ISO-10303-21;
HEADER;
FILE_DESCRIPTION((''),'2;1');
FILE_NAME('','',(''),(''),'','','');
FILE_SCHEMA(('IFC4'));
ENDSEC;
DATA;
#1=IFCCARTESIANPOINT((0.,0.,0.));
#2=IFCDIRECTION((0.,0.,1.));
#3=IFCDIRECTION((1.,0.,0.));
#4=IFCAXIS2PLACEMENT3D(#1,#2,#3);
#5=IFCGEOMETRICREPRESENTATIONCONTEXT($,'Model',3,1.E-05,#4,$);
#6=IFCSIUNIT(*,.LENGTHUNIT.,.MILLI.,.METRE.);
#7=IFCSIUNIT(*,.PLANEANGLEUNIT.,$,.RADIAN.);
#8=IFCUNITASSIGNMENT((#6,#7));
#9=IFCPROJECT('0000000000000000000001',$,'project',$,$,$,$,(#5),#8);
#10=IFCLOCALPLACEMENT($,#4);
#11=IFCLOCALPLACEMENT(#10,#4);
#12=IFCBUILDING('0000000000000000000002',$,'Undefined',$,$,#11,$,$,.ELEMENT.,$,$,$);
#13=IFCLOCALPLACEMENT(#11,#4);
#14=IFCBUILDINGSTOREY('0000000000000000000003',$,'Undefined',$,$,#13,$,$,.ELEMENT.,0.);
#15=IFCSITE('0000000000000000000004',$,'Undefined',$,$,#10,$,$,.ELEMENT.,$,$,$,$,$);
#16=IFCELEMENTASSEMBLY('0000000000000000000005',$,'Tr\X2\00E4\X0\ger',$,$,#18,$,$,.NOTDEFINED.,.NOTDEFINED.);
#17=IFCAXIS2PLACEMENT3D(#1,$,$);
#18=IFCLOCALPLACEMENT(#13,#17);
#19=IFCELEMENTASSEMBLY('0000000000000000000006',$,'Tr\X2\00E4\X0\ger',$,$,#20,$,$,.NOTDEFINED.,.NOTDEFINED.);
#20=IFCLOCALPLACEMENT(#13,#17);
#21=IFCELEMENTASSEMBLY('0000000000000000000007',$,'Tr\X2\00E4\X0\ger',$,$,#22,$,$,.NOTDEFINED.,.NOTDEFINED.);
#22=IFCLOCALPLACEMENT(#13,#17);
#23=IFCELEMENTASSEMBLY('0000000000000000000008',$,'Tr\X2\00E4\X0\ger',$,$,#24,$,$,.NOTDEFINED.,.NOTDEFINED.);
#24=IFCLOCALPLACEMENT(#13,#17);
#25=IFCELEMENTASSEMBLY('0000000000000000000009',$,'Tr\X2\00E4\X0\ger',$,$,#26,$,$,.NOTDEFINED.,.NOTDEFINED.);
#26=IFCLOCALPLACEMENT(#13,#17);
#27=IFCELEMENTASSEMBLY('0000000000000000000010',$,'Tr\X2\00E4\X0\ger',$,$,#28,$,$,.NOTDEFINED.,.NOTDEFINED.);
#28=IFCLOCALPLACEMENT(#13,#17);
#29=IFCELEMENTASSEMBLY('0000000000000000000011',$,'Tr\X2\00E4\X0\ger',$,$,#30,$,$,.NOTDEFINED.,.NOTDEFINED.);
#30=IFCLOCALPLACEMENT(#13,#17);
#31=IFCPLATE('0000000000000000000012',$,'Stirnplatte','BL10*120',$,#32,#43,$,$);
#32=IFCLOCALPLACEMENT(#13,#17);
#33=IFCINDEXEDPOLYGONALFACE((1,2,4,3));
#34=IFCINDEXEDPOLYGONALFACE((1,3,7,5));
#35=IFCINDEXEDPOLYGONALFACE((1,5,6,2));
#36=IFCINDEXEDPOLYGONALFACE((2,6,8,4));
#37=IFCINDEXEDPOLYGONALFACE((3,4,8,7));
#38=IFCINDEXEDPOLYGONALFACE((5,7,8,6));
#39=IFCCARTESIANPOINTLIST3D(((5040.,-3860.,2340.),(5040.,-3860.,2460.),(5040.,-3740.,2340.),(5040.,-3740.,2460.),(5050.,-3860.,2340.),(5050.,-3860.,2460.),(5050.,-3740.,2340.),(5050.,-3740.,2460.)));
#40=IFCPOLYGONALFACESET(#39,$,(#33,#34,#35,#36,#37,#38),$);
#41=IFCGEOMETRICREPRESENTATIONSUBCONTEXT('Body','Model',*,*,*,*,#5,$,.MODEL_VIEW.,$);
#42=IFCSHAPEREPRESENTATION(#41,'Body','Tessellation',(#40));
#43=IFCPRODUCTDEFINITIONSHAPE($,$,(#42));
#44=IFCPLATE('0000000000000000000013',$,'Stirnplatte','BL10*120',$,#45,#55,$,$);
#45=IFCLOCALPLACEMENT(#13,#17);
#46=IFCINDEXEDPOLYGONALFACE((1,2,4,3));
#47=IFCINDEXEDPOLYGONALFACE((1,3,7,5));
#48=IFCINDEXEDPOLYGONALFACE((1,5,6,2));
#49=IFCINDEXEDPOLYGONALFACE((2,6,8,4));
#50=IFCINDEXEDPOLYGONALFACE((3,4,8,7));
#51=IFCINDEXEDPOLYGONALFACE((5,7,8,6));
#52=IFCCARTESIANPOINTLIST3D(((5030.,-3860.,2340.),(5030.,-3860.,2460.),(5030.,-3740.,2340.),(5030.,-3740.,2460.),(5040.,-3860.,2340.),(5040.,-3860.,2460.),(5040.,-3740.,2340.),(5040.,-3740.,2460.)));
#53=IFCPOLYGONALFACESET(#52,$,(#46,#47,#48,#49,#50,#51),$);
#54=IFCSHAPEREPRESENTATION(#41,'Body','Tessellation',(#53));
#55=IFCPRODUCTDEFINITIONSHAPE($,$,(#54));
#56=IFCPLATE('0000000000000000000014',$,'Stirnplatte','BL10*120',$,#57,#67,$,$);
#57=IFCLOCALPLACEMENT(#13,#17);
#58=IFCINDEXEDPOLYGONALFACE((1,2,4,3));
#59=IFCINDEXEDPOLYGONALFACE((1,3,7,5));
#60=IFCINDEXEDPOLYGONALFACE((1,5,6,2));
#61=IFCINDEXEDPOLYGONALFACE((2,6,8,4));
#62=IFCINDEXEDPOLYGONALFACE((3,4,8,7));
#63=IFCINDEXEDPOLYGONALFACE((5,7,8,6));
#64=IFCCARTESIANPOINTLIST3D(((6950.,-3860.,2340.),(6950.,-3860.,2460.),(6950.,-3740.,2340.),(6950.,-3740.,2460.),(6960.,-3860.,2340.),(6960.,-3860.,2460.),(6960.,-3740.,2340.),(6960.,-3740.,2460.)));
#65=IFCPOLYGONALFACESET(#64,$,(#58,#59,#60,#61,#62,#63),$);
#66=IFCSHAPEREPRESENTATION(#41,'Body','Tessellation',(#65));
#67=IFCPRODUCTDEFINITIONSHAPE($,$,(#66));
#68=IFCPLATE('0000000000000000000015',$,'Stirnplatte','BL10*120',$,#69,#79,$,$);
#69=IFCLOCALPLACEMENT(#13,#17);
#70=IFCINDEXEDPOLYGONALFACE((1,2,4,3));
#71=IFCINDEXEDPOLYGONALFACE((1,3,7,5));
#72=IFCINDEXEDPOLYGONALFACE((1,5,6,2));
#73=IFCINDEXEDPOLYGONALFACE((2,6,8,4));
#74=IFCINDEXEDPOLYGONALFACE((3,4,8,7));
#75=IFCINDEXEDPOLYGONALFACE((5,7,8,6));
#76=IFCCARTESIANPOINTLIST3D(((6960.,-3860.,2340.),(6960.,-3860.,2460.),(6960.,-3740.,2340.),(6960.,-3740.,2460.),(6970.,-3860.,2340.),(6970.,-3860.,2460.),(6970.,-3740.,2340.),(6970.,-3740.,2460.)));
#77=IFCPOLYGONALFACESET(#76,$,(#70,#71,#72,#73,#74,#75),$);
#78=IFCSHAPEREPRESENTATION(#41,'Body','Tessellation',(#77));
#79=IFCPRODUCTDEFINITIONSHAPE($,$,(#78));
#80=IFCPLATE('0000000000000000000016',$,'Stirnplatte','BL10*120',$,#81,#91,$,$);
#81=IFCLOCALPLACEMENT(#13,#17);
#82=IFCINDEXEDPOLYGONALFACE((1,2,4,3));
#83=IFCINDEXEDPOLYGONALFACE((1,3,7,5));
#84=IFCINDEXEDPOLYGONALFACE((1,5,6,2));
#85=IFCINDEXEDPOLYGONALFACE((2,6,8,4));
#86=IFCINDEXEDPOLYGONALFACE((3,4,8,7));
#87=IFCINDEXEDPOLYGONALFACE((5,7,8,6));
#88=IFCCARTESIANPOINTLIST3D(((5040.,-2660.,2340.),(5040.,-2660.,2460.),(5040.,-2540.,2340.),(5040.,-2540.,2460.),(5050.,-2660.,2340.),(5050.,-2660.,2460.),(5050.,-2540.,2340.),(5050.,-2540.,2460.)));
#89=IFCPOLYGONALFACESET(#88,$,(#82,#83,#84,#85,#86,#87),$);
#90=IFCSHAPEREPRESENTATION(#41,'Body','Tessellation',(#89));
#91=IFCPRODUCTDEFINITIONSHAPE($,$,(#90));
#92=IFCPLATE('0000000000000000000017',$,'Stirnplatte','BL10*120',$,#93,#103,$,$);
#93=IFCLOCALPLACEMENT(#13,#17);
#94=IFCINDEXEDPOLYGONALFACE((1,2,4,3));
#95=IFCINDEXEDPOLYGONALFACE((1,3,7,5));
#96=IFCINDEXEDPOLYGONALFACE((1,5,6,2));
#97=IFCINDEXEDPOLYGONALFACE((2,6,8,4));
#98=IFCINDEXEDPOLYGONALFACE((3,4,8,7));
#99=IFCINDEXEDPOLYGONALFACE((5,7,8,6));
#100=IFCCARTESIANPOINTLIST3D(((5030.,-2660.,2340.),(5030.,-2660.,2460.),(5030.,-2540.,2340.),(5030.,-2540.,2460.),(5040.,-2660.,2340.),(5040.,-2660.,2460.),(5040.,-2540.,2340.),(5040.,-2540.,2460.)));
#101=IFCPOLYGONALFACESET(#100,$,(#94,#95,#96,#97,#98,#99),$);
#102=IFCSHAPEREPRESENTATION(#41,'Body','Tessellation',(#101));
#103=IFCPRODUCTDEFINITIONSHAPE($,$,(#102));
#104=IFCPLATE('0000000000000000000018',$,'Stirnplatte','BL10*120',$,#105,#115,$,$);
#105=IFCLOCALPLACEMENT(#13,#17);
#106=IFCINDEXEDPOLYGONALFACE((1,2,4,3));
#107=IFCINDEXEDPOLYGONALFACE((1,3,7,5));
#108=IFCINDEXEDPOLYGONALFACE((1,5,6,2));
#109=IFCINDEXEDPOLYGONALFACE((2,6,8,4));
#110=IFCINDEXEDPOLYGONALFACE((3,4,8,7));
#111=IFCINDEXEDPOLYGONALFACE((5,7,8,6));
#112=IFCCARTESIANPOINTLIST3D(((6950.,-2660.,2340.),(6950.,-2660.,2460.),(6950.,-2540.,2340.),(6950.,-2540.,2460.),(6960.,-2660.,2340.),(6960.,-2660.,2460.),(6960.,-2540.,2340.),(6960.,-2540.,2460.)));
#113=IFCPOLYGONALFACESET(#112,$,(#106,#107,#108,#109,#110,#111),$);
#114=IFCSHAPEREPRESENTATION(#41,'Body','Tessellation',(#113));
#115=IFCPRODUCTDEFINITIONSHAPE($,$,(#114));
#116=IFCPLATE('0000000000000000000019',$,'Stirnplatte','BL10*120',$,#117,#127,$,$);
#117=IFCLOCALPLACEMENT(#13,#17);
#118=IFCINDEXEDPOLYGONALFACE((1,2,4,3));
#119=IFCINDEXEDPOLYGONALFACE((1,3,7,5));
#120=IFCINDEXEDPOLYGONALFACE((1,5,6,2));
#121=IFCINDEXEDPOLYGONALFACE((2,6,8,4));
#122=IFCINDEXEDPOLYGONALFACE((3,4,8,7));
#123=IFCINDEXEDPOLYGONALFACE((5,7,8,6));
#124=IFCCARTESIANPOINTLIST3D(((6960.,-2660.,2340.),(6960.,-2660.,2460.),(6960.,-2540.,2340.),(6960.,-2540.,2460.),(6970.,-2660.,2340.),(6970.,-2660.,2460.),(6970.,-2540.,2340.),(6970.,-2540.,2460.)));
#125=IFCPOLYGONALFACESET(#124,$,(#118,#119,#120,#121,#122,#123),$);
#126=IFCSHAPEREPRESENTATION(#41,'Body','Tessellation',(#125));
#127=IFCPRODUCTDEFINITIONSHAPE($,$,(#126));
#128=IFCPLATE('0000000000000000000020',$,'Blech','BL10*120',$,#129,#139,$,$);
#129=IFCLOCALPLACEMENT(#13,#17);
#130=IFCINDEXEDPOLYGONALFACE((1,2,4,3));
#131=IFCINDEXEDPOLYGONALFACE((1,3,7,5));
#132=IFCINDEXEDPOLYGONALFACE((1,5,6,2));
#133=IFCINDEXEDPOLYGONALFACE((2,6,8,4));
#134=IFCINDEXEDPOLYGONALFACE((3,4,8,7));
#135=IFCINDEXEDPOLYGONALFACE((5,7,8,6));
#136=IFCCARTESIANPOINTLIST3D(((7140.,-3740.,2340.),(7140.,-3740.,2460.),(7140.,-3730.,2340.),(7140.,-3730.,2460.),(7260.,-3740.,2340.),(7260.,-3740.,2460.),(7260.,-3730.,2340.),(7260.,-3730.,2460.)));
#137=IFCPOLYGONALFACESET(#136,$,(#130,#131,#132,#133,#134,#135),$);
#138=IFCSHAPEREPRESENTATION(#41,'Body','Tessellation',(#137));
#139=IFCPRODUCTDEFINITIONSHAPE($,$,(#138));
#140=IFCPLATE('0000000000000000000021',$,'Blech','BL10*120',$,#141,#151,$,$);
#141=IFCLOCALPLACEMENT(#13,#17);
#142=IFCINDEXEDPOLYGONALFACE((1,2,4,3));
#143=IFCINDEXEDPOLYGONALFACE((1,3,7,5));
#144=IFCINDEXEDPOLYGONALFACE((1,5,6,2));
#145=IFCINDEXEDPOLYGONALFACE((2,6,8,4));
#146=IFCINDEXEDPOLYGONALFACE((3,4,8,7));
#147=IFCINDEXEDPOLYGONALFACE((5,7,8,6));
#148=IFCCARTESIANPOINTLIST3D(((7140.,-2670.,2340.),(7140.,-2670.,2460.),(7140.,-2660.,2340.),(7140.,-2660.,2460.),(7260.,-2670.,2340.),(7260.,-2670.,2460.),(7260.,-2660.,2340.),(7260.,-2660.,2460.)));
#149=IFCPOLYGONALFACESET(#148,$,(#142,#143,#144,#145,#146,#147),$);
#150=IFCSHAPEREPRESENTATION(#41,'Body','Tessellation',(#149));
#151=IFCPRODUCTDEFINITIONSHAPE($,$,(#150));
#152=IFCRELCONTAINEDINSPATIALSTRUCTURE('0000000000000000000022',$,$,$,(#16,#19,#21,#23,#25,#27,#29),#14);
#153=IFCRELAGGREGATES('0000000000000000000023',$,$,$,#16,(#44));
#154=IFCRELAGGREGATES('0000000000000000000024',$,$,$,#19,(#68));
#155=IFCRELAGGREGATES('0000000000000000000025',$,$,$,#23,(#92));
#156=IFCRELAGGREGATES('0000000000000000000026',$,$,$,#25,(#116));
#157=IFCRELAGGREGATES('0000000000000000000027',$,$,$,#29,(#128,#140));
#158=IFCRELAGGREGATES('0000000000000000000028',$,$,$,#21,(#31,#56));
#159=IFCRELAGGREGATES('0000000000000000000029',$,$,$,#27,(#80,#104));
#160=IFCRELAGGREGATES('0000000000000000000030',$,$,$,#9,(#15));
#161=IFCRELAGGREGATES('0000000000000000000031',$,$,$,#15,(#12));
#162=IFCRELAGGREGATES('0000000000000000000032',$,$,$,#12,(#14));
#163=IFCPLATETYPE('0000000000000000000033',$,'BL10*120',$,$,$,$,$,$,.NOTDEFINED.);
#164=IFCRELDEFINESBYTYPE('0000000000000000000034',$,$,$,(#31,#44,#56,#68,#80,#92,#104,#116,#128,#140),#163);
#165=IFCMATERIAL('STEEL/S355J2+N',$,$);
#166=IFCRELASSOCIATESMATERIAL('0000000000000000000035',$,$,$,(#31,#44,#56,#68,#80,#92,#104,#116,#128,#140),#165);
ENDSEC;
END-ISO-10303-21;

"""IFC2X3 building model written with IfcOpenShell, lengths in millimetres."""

from ifc_helpers import new_model, si_unit, frame, origin_with_axes, place, context, subcontext, project, spatial, polyline, outline, extrude, material, type_object, element, aggregate, save


model = new_model("IFC2X3")

# Units and contexts
model_context = context("Model", 3, precision=1e-05, world=origin_with_axes())
body_context = subcontext(model_context, "Body", "Model", "MODEL_VIEW")
ifc_project = project(units=[si_unit("LENGTHUNIT", "METRE", prefix="MILLI"), si_unit("PLANEANGLEUNIT", "RADIAN")], contexts=[model_context])

# Site, building, storey
site_placement = place(None, origin_with_axes())
site = spatial("IfcSite", under=ifc_project, at=site_placement, Name="Undefined", CompositionType="ELEMENT")
building_placement = place(site_placement, origin_with_axes())
building = spatial("IfcBuilding", under=site, at=building_placement, Name="Undefined", CompositionType="ELEMENT")
storey_placement = place(building_placement, origin_with_axes())
storey = spatial("IfcBuildingStorey", under=building, at=storey_placement, Name="Undefined", CompositionType="ELEMENT", Elevation=0.0)

# Element assemblies
assembly_1_placement = place(storey_placement, origin_with_axes())
assembly_1 = element("IfcElementAssembly", 1, at=assembly_1_placement, inside=storey, Name="Träger", AssemblyPlace="NOTDEFINED", PredefinedType="NOTDEFINED")
assembly_2_placement = place(storey_placement, origin_with_axes())
assembly_2 = element("IfcElementAssembly", 2, at=assembly_2_placement, inside=storey, Name="Träger", AssemblyPlace="NOTDEFINED", PredefinedType="NOTDEFINED")
assembly_3_placement = place(storey_placement, origin_with_axes())
assembly_3 = element("IfcElementAssembly", 3, at=assembly_3_placement, inside=storey, Name="Träger", AssemblyPlace="NOTDEFINED", PredefinedType="NOTDEFINED")
assembly_4_placement = place(storey_placement, origin_with_axes())
assembly_4 = element("IfcElementAssembly", 4, at=assembly_4_placement, inside=storey, Name="Träger", AssemblyPlace="NOTDEFINED", PredefinedType="NOTDEFINED")
assembly_5_placement = place(storey_placement, origin_with_axes())
assembly_5 = element("IfcElementAssembly", 5, at=assembly_5_placement, inside=storey, Name="Träger", AssemblyPlace="NOTDEFINED", PredefinedType="NOTDEFINED")
assembly_6_placement = place(storey_placement, origin_with_axes())
assembly_6 = element("IfcElementAssembly", 6, at=assembly_6_placement, inside=storey, Name="Träger", AssemblyPlace="NOTDEFINED", PredefinedType="NOTDEFINED")
assembly_7_placement = place(storey_placement, origin_with_axes())
assembly_7 = element("IfcElementAssembly", 7, at=assembly_7_placement, inside=storey, Name="Träger", AssemblyPlace="NOTDEFINED", PredefinedType="NOTDEFINED")

# Plates
ifc_material_1 = material(Name="STEEL/S355J2+N")
plate_type = type_object("IfcPlateType", Name="BL10*120", PredefinedType="NOTDEFINED")
plate_1_placement = place(assembly_3_placement, frame((5045.0, -3800.0, 2340.0), z_axis=(1.0, 0.0, 0.0), x_axis=(0.0, 0.0, 1.0)))
plate_1 = element("IfcPlate", 8, at=plate_1_placement, type_object=plate_type, material=ifc_material_1, Name="Stirnplatte", Description="BL10*120", context=body_context, shape_type="SweptSolid", body=[
    extrude(outline(polyline([(0.0, -60.0), (0.0, 60.0), (120.0, 60.0), (120.0, -60.0), (0.0, -60.0)])), frame((0.0, 0.0, -5.0), z_axis=(0.0, 0.0, 1.0), x_axis=(1.0, 0.0, 0.0)), (0.0, 0.0, 1.0), 10.0),
])
plate_2_placement = place(assembly_1_placement, frame((5035.0, -3800.0, 2340.0), z_axis=(1.0, 0.0, 0.0), x_axis=(0.0, 0.0, 1.0)))
plate_2 = element("IfcPlate", 9, at=plate_2_placement, type_object=plate_type, material=ifc_material_1, Name="Stirnplatte", Description="BL10*120", context=body_context, shape_type="SweptSolid", body=[
    extrude(outline(polyline([(0.0, -60.0), (0.0, 60.0), (120.0, 60.0), (120.0, -60.0), (0.0, -60.0)])), frame((0.0, 0.0, -5.0), z_axis=(0.0, 0.0, 1.0), x_axis=(1.0, 0.0, 0.0)), (0.0, 0.0, 1.0), 10.0),
])
aggregate(assembly_1, [plate_2])
plate_3_placement = place(assembly_3_placement, frame((6955.0, -3800.0, 2340.0), z_axis=(-1.0, 0.0, 0.0), x_axis=(0.0, 0.0, 1.0)))
plate_3 = element("IfcPlate", 10, at=plate_3_placement, type_object=plate_type, material=ifc_material_1, Name="Stirnplatte", Description="BL10*120", context=body_context, shape_type="SweptSolid", body=[
    extrude(outline(polyline([(0.0, -60.0), (0.0, 60.0), (120.0, 60.0), (120.0, -60.0), (0.0, -60.0)])), frame((0.0, 0.0, -5.0), z_axis=(0.0, 0.0, 1.0), x_axis=(1.0, 0.0, 0.0)), (0.0, 0.0, 1.0), 10.0),
])
plate_4_placement = place(assembly_2_placement, frame((6965.0, -3800.0, 2340.0), z_axis=(-1.0, 0.0, 0.0), x_axis=(0.0, 0.0, 1.0)))
plate_4 = element("IfcPlate", 11, at=plate_4_placement, type_object=plate_type, material=ifc_material_1, Name="Stirnplatte", Description="BL10*120", context=body_context, shape_type="SweptSolid", body=[
    extrude(outline(polyline([(0.0, -60.0), (0.0, 60.0), (120.0, 60.0), (120.0, -60.0), (0.0, -60.0)])), frame((0.0, 0.0, -5.0), z_axis=(0.0, 0.0, 1.0), x_axis=(1.0, 0.0, 0.0)), (0.0, 0.0, 1.0), 10.0),
])
aggregate(assembly_2, [plate_4])
plate_5_placement = place(assembly_6_placement, frame((5045.0, -2600.0, 2340.0), z_axis=(1.0, 0.0, 0.0), x_axis=(0.0, 0.0, 1.0)))
plate_5 = element("IfcPlate", 12, at=plate_5_placement, type_object=plate_type, material=ifc_material_1, Name="Stirnplatte", Description="BL10*120", context=body_context, shape_type="SweptSolid", body=[
    extrude(outline(polyline([(0.0, -60.0), (0.0, 60.0), (120.0, 60.0), (120.0, -60.0), (0.0, -60.0)])), frame((0.0, 0.0, -5.0), z_axis=(0.0, 0.0, 1.0), x_axis=(1.0, 0.0, 0.0)), (0.0, 0.0, 1.0), 10.0),
])
plate_6_placement = place(assembly_4_placement, frame((5035.0, -2600.0, 2340.0), z_axis=(1.0, 0.0, 0.0), x_axis=(0.0, 0.0, 1.0)))
plate_6 = element("IfcPlate", 13, at=plate_6_placement, type_object=plate_type, material=ifc_material_1, Name="Stirnplatte", Description="BL10*120", context=body_context, shape_type="SweptSolid", body=[
    extrude(outline(polyline([(0.0, -60.0), (0.0, 60.0), (120.0, 60.0), (120.0, -60.0), (0.0, -60.0)])), frame((0.0, 0.0, -5.0), z_axis=(0.0, 0.0, 1.0), x_axis=(1.0, 0.0, 0.0)), (0.0, 0.0, 1.0), 10.0),
])
aggregate(assembly_4, [plate_6])
plate_7_placement = place(assembly_6_placement, frame((6955.0, -2600.0, 2340.0), z_axis=(-1.0, 0.0, 0.0), x_axis=(0.0, 0.0, 1.0)))
plate_7 = element("IfcPlate", 14, at=plate_7_placement, type_object=plate_type, material=ifc_material_1, Name="Stirnplatte", Description="BL10*120", context=body_context, shape_type="SweptSolid", body=[
    extrude(outline(polyline([(0.0, -60.0), (0.0, 60.0), (120.0, 60.0), (120.0, -60.0), (0.0, -60.0)])), frame((0.0, 0.0, -5.0), z_axis=(0.0, 0.0, 1.0), x_axis=(1.0, 0.0, 0.0)), (0.0, 0.0, 1.0), 10.0),
])
plate_8_placement = place(assembly_5_placement, frame((6965.0, -2600.0, 2340.0), z_axis=(-1.0, 0.0, 0.0), x_axis=(0.0, 0.0, 1.0)))
plate_8 = element("IfcPlate", 15, at=plate_8_placement, type_object=plate_type, material=ifc_material_1, Name="Stirnplatte", Description="BL10*120", context=body_context, shape_type="SweptSolid", body=[
    extrude(outline(polyline([(0.0, -60.0), (0.0, 60.0), (120.0, 60.0), (120.0, -60.0), (0.0, -60.0)])), frame((0.0, 0.0, -5.0), z_axis=(0.0, 0.0, 1.0), x_axis=(1.0, 0.0, 0.0)), (0.0, 0.0, 1.0), 10.0),
])
aggregate(assembly_5, [plate_8])
plate_9_placement = place(assembly_7_placement, frame((7200.0, -3735.0, 2340.0), z_axis=(0.0, 1.0, 0.0), x_axis=(0.0, 0.0, 1.0)))
plate_9 = element("IfcPlate", 16, at=plate_9_placement, type_object=plate_type, material=ifc_material_1, Name="Blech", Description="BL10*120", context=body_context, shape_type="SweptSolid", body=[
    extrude(outline(polyline([(0.0, -60.0), (0.0, 60.0), (120.0, 60.0), (120.0, -60.0), (0.0, -60.0)])), frame((0.0, 0.0, -5.0), z_axis=(0.0, 0.0, 1.0), x_axis=(1.0, 0.0, 0.0)), (0.0, 0.0, 1.0), 10.0),
])
plate_10_placement = place(assembly_7_placement, frame((7200.0, -2665.0, 2340.0), z_axis=(0.0, -1.0, 0.0), x_axis=(0.0, 0.0, 1.0)))
plate_10 = element("IfcPlate", 17, at=plate_10_placement, type_object=plate_type, material=ifc_material_1, Name="Blech", Description="BL10*120", context=body_context, shape_type="SweptSolid", body=[
    extrude(outline(polyline([(0.0, -60.0), (0.0, 60.0), (120.0, 60.0), (120.0, -60.0), (0.0, -60.0)])), frame((0.0, 0.0, -5.0), z_axis=(0.0, 0.0, 1.0), x_axis=(1.0, 0.0, 0.0)), (0.0, 0.0, 1.0), 10.0),
])
aggregate(assembly_7, [plate_9, plate_10])

aggregate(assembly_3, [plate_1, plate_3])
aggregate(assembly_6, [plate_5, plate_7])

save(model, "model.ifc")
